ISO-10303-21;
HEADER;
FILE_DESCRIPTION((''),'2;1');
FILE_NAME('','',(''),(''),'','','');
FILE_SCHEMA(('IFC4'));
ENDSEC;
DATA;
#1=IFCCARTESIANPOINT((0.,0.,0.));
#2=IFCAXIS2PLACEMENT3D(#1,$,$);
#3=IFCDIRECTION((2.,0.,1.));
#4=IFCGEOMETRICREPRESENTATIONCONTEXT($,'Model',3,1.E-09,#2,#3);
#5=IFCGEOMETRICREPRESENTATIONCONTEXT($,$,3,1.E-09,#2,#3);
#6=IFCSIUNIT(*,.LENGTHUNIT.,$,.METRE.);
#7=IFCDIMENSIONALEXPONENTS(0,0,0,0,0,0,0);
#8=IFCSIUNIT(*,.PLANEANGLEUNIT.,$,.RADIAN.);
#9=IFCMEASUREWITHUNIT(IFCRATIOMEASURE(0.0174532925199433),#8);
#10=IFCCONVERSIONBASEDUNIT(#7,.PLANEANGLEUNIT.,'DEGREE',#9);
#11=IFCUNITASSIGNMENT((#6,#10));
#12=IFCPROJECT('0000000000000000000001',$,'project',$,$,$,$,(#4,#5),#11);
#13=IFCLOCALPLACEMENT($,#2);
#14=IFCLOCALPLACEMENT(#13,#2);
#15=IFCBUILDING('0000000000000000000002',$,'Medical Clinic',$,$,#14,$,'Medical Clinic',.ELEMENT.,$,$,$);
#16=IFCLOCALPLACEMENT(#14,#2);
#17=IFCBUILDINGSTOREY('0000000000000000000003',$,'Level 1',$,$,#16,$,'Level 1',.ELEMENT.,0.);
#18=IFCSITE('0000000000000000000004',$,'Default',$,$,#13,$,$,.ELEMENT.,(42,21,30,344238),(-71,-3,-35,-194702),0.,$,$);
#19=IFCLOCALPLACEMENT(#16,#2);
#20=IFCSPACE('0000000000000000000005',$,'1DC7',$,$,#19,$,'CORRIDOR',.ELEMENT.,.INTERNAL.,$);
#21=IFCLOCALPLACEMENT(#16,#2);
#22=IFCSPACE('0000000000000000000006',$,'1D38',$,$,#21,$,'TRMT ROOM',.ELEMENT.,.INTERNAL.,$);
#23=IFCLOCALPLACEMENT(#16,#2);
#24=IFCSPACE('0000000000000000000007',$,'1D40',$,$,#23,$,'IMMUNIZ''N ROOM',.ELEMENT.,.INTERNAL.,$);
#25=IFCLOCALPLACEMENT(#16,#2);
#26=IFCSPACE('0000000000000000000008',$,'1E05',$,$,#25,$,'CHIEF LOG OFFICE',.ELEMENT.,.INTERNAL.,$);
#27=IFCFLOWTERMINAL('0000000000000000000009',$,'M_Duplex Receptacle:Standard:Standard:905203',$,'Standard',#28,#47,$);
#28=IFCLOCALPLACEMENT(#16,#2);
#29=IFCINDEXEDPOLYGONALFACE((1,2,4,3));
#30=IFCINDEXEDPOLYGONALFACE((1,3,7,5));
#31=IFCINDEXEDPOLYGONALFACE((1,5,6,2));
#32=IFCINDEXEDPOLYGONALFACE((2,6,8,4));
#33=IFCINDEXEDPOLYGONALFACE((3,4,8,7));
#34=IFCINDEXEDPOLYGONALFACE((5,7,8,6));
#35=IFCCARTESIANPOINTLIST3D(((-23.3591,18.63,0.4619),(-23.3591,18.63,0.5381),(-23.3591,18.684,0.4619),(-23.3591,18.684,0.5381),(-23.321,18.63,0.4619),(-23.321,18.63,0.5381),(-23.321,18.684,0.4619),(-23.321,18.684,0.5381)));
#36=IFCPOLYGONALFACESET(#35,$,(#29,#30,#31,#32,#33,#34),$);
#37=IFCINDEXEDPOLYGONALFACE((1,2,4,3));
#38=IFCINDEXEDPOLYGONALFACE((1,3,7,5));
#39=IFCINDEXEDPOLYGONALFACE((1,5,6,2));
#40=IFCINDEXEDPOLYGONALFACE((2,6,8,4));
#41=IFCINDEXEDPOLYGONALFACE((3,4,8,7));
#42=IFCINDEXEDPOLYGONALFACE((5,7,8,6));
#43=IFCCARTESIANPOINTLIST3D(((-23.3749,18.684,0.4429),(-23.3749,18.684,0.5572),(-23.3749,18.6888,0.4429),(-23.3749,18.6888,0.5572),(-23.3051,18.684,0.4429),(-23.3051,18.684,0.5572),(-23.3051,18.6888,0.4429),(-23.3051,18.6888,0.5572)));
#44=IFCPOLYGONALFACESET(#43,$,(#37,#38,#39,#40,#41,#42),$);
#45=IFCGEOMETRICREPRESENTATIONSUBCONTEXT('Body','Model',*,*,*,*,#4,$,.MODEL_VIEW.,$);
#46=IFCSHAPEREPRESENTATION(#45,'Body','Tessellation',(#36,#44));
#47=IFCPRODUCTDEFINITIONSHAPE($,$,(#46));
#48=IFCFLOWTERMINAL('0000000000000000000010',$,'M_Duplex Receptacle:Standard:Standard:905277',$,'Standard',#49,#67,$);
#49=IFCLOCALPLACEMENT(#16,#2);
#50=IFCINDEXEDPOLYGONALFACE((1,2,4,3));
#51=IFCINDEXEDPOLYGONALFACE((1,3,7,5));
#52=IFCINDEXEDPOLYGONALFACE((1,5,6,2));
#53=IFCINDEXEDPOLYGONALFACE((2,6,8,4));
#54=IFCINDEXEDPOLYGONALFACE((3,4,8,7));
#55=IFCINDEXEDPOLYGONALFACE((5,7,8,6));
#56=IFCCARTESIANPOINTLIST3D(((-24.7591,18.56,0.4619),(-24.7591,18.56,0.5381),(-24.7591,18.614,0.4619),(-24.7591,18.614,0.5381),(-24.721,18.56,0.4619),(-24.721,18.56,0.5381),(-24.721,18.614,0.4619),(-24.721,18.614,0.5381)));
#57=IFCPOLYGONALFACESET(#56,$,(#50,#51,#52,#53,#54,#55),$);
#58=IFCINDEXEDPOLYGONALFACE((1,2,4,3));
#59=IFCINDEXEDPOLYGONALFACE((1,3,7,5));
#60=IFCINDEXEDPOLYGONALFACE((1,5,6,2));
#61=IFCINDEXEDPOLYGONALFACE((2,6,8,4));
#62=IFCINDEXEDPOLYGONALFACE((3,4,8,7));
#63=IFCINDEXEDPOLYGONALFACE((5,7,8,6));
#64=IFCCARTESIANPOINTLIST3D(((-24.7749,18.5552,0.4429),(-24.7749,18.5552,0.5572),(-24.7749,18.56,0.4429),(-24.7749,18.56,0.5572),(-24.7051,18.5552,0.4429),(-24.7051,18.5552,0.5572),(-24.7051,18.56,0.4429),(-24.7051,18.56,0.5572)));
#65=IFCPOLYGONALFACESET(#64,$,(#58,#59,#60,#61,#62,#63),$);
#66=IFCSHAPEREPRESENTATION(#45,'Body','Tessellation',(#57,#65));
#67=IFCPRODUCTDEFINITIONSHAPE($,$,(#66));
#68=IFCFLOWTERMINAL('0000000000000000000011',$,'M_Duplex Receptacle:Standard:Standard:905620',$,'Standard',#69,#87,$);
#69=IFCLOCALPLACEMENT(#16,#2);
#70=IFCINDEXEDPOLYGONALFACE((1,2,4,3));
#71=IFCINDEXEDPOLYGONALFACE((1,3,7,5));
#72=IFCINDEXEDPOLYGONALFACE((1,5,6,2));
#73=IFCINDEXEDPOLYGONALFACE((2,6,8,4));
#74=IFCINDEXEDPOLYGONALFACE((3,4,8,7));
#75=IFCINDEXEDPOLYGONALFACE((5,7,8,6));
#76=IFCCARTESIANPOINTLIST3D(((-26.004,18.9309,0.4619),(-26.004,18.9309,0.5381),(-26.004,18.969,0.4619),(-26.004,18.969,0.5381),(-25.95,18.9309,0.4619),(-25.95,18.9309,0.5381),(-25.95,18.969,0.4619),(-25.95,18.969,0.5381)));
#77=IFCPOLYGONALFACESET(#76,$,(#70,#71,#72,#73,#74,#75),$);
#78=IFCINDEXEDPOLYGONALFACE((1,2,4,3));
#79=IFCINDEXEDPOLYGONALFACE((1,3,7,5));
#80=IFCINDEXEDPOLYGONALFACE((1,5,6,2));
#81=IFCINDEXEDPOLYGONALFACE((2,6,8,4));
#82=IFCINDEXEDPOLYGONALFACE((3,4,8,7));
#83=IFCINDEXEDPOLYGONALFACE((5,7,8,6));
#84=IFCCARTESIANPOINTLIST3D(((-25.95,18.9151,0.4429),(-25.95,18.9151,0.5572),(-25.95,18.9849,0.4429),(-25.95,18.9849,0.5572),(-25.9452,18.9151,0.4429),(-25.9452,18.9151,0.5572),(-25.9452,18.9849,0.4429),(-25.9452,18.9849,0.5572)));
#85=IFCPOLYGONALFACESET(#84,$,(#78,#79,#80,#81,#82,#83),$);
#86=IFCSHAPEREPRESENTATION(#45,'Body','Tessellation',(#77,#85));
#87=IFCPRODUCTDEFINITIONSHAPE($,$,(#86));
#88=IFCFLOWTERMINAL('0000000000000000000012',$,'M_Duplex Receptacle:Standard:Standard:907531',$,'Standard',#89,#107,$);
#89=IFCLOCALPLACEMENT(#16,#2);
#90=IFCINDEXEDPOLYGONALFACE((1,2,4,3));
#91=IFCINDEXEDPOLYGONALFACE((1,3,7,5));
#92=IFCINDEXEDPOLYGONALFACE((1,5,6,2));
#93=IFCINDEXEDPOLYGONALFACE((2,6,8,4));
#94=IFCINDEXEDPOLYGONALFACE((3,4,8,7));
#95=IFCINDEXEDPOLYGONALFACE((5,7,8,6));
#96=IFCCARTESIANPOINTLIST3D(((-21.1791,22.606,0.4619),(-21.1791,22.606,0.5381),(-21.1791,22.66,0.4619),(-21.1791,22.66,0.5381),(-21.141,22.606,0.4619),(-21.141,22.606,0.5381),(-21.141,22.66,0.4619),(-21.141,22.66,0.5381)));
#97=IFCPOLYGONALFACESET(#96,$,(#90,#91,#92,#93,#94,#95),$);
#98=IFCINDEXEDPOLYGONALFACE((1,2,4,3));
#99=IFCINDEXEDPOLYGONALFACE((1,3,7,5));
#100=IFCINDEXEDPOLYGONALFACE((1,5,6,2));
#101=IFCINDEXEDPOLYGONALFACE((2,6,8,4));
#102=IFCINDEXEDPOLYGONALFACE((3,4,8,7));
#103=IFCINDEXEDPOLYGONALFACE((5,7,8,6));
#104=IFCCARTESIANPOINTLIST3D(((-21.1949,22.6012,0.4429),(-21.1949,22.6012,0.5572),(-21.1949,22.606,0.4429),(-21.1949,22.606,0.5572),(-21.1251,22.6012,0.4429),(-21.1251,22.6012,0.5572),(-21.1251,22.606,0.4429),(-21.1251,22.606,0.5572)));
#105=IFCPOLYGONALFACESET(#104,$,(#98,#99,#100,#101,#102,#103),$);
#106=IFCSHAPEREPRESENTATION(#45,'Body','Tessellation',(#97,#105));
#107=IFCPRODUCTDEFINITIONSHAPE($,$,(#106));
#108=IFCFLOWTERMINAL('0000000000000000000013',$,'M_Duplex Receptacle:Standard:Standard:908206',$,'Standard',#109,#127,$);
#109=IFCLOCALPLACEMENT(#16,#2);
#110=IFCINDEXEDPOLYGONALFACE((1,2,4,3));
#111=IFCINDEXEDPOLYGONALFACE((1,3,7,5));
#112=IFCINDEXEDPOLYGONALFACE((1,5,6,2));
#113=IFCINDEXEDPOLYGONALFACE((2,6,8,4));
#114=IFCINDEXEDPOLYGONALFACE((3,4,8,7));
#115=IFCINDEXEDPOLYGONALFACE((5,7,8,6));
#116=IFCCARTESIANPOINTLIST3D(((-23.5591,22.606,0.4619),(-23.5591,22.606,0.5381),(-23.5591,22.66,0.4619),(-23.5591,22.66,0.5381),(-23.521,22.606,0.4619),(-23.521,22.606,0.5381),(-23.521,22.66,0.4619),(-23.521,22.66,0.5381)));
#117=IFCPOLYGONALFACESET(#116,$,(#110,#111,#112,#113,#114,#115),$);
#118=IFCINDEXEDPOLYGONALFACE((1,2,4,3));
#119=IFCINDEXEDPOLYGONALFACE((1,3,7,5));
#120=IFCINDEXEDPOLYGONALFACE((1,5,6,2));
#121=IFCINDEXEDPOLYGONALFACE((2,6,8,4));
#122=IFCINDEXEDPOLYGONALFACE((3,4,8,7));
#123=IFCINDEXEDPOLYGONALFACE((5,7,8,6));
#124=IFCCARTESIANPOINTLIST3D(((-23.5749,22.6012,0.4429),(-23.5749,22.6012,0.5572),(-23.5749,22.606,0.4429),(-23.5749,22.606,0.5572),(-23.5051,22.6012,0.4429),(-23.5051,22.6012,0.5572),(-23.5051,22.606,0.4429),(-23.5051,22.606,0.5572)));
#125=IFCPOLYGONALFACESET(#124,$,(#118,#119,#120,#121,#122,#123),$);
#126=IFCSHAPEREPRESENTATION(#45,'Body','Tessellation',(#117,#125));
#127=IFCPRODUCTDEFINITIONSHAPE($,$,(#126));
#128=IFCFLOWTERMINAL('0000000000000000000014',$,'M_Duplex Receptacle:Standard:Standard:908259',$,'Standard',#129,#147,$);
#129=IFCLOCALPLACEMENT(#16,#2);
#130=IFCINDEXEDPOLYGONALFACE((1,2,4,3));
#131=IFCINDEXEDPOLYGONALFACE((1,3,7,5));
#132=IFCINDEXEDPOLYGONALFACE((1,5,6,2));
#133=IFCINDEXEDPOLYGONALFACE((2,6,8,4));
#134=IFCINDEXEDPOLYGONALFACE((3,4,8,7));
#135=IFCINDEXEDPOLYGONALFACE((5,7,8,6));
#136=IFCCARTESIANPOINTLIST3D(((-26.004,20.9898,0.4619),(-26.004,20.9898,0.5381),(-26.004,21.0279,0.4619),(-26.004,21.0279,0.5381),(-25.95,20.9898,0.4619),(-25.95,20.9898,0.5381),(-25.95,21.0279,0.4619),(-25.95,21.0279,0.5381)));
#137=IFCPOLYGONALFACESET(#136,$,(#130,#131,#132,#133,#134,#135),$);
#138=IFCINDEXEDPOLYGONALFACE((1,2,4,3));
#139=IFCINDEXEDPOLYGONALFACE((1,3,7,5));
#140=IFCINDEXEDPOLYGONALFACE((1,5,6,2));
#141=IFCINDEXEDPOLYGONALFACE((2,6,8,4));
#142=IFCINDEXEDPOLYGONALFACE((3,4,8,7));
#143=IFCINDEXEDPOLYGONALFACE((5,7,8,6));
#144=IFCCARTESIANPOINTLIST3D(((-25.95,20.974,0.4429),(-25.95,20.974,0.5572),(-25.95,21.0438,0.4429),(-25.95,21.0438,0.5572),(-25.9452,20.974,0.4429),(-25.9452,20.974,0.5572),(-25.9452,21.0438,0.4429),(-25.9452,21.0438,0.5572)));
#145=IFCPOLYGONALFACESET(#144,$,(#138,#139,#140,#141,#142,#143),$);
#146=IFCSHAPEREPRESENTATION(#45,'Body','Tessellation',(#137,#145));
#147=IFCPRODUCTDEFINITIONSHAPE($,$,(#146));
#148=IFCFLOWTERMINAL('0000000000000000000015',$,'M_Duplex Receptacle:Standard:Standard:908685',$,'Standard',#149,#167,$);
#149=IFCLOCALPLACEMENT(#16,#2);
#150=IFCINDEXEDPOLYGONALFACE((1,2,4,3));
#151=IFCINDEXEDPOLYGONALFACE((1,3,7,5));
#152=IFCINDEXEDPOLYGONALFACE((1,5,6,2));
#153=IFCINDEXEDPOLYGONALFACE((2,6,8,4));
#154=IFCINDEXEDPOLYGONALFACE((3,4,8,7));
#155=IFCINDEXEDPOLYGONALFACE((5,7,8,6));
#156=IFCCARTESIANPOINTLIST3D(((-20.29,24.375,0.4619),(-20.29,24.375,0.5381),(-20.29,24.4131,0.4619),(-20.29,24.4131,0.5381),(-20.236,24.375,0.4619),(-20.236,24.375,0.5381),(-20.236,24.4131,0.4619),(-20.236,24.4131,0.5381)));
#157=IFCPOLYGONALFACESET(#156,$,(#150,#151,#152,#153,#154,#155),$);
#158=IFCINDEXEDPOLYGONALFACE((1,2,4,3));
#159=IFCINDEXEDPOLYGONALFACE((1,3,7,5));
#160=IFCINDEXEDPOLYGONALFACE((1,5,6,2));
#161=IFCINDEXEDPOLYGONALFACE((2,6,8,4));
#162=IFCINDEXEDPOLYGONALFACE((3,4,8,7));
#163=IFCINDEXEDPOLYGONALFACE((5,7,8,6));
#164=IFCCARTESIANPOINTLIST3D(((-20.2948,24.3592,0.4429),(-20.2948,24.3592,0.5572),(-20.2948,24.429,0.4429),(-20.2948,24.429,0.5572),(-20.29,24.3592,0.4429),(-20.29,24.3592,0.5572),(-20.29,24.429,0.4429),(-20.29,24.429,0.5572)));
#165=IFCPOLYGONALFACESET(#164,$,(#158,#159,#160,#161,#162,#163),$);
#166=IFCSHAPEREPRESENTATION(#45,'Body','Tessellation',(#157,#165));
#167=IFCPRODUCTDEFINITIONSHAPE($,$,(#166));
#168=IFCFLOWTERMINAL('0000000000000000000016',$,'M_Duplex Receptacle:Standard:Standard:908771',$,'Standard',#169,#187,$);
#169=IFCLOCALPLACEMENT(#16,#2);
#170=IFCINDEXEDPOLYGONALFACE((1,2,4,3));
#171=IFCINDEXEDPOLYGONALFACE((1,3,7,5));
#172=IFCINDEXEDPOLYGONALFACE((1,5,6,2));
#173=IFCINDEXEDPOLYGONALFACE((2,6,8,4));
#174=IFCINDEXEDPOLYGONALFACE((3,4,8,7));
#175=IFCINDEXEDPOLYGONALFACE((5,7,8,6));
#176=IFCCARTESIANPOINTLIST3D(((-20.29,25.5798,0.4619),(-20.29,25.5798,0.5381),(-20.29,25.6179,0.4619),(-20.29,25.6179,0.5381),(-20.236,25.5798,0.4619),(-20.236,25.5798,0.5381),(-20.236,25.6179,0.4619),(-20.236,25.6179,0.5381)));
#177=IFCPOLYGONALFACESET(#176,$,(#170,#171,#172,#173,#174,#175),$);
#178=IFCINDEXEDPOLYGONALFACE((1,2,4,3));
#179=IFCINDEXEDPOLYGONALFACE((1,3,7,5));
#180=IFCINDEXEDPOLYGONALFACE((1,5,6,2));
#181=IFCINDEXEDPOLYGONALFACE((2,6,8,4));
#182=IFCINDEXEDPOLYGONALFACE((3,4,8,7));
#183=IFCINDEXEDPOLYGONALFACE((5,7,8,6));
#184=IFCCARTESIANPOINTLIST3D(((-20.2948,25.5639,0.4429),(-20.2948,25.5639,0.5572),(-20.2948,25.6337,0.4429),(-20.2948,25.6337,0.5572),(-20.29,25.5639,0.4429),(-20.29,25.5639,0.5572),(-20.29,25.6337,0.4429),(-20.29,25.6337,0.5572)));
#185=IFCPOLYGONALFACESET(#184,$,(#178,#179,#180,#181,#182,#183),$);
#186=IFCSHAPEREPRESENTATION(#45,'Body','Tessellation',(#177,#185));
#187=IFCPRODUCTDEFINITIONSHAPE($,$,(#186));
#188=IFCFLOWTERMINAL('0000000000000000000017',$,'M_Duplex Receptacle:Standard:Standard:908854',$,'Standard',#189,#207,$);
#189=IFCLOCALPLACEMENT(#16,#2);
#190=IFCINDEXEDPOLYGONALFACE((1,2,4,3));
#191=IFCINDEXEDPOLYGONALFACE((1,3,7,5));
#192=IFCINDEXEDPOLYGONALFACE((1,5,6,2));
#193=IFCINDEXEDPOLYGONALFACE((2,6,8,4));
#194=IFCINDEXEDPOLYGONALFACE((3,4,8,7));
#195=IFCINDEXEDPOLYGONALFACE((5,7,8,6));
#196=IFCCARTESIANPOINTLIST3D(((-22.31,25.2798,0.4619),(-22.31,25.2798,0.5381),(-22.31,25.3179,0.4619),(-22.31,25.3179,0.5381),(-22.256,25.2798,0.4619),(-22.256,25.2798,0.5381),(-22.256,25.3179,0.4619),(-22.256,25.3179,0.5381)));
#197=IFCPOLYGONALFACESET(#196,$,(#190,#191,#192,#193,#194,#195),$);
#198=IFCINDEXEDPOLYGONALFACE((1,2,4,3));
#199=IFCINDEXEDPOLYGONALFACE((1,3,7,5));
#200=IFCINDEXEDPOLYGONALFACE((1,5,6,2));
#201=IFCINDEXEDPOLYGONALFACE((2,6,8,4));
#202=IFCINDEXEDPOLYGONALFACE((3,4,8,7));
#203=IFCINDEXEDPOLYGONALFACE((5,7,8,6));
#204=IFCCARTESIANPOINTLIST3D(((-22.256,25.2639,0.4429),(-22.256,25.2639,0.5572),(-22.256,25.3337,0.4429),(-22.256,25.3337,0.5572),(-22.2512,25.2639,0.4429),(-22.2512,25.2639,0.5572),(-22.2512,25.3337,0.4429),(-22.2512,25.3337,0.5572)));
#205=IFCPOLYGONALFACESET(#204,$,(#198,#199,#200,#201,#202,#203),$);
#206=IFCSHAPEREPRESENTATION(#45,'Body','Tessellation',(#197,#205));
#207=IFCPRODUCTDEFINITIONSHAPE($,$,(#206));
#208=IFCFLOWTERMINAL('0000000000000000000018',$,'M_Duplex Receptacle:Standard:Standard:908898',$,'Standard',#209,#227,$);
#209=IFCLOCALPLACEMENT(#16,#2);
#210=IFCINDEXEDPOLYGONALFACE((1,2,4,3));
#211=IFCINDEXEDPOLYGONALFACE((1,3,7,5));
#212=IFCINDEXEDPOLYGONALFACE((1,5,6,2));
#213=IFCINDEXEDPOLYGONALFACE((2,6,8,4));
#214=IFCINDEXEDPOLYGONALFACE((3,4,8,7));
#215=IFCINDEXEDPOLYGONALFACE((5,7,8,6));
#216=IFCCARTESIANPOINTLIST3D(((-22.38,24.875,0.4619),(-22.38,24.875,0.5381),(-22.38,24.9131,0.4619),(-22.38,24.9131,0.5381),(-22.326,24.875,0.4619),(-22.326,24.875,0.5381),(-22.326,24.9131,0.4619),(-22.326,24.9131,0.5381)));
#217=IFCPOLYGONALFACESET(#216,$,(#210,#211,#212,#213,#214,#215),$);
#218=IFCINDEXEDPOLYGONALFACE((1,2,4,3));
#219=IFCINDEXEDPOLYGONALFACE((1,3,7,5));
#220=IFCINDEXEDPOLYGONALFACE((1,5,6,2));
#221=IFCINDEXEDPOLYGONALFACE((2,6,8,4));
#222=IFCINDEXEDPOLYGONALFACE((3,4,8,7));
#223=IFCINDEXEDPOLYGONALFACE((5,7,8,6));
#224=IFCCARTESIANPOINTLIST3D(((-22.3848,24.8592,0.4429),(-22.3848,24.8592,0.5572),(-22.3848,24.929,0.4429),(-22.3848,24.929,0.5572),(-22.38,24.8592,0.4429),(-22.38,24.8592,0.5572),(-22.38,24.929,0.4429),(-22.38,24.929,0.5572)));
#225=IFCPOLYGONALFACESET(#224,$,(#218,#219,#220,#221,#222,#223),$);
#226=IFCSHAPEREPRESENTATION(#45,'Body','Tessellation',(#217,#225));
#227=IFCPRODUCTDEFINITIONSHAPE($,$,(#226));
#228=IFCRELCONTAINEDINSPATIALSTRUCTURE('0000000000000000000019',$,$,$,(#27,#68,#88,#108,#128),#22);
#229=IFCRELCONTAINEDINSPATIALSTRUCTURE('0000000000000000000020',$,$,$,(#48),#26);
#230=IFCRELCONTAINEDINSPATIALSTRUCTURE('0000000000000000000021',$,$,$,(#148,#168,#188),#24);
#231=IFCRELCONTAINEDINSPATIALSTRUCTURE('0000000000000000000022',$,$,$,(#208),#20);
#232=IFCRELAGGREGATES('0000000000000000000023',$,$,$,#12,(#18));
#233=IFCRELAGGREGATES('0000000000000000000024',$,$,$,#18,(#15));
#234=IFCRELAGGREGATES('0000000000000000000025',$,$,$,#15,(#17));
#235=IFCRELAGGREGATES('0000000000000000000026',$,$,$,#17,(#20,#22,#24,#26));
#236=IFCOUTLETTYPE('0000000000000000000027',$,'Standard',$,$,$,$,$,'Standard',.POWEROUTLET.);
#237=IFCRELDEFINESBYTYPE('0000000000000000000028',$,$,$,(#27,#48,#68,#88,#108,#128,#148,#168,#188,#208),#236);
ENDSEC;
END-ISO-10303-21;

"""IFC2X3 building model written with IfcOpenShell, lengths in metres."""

from ifc_helpers import new_model, entity, si_unit, converted_unit, direction, frame, frame_2d, origin, origin_2d_with_axis, place, context, subcontext, project, spatial, rectangle, extrude, source, transform, mapped, type_object, type_shapes, element, save


model = new_model("IFC2X3")

# Units and contexts
model_context = context("Model", 3, precision=1e-09, world=origin(), true_north=direction((2.0, 0.0, 1.0)))
context_of_model = context(None, 3, precision=1e-09, world=origin(), true_north=direction((2.0, 0.0, 1.0)))
body_context = subcontext(model_context, "Body", "Model", "MODEL_VIEW")
ifc_project = project(units=[si_unit("LENGTHUNIT", "METRE"), converted_unit("PLANEANGLEUNIT", "DEGREE", entity("IfcRatioMeasure", 0.0174532925199433), si_unit("PLANEANGLEUNIT", "RADIAN"), dimensions=[0, 0, 0, 0, 0, 0, 0])], contexts=[model_context, context_of_model])

# Site, building, storey, space
site_placement = place(None, origin())
site = spatial("IfcSite", under=ifc_project, at=site_placement, Name="Default", CompositionType="ELEMENT", RefLatitude=(42, 21, 30, 344238), RefLongitude=(-71, -3, -35, -194702), RefElevation=0.0)
building_placement = place(site_placement, origin())
building = spatial("IfcBuilding", under=site, at=building_placement, Name="Medical Clinic", LongName="Medical Clinic", CompositionType="ELEMENT")
storey_placement = place(building_placement, origin())
storey = spatial("IfcBuildingStorey", under=building, at=storey_placement, Name="Level 1", LongName="Level 1", CompositionType="ELEMENT", Elevation=0.0)
space_1_placement = place(storey_placement, origin())
space_1 = spatial("IfcSpace", under=storey, at=space_1_placement, Name="1DC7", LongName="CORRIDOR", CompositionType="ELEMENT", InteriorOrExteriorSpace="INTERNAL")

# Shared definitions
space_2_placement = place(storey_placement, origin())
space_2 = spatial("IfcSpace", under=storey, at=space_2_placement, Name="1D38", LongName="TRMT ROOM", CompositionType="ELEMENT", InteriorOrExteriorSpace="INTERNAL")

# Shared definitions
space_3_placement = place(storey_placement, origin())
space_3 = spatial("IfcSpace", under=storey, at=space_3_placement, Name="1D40", LongName="IMMUNIZ'N ROOM", CompositionType="ELEMENT", InteriorOrExteriorSpace="INTERNAL")

# Flow terminal
outlet_type = type_object("IfcOutletType", Name="Standard", ElementType="Standard", PredefinedType="POWEROUTLET")
shared_shape_1 = source(origin(), body_context, "Body", "SweptSolid", [
    extrude(rectangle(XDim=0.0381, YDim=0.0762, at=origin_2d_with_axis()), frame((0.0, 0.0, -0.054), z_axis=(0.0, 0.0, 1.0), x_axis=(-1.0, 0.0, 0.0)), (0.0, 0.0, 1.0), 0.054),
    extrude(rectangle(XDim=0.0698, YDim=0.1143, at=frame_2d((0.0, 0.0), x_axis=(1.0, 0.0))), frame((0.0, 0.0, 0.0), z_axis=(0.0, 0.0, 1.0), x_axis=(-1.0, 0.0, 0.0)), (0.0, 0.0, 1.0), 0.0048),
])
type_shapes(outlet_type, [shared_shape_1])
for number, where, z_axis, x_axis, name in (
    (1, (-23.34, 18.684, 0.5), (0.0, 1.0, 0.0), (-1.0, 0.0, 0.0), "M_Duplex Receptacle:Standard:Standard:905203"),
):
    element("IfcFlowTerminal", number, at=place(space_2_placement, frame(where, z_axis=z_axis, x_axis=x_axis)), inside=space_2, type_object=outlet_type, Name=name, ObjectType="Standard", context=body_context, shape_type="MappedRepresentation", body=[
        mapped(shared_shape_1, transform((0.0, 0.0, 0.0), scale=1.0)),
    ])

# Shared definitions
space_4_placement = place(storey_placement, origin())
space_4 = spatial("IfcSpace", under=storey, at=space_4_placement, Name="1E05", LongName="CHIEF LOG OFFICE", CompositionType="ELEMENT", InteriorOrExteriorSpace="INTERNAL")

# Flow terminals
flow_terminal_1_placement = place(space_4_placement, frame((-24.74, 18.56, 0.5), z_axis=(0.0, -1.0, 0.0), x_axis=(1.0, 0.0, 0.0)))
element("IfcFlowTerminal", 2, at=flow_terminal_1_placement, inside=space_4, type_object=outlet_type, Name="M_Duplex Receptacle:Standard:Standard:905277", ObjectType="Standard", context=body_context, shape_type="MappedRepresentation", body=[
    mapped(shared_shape_1, transform((0.0, 0.0, 0.0), scale=1.0)),
])
for number, where, z_axis, x_axis, name in (
    (3, (-25.95, 18.95, 0.5), (1.0, 0.0, 0.0), (0.0, 1.0, 0.0), "M_Duplex Receptacle:Standard:Standard:905620"),
    (4, (-21.16, 22.606, 0.5), (0.0, -1.0, 0.0), (1.0, 0.0, 0.0), "M_Duplex Receptacle:Standard:Standard:907531"),
    (5, (-23.54, 22.606, 0.5), (0.0, -1.0, 0.0), (1.0, 0.0, 0.0), "M_Duplex Receptacle:Standard:Standard:908206"),
    (6, (-25.95, 21.0089, 0.5), (1.0, 0.0, 0.0), (0.0, 1.0, 0.0), "M_Duplex Receptacle:Standard:Standard:908259"),
):
    element("IfcFlowTerminal", number, at=place(space_2_placement, frame(where, z_axis=z_axis, x_axis=x_axis)), inside=space_2, type_object=outlet_type, Name=name, ObjectType="Standard", context=body_context, shape_type="MappedRepresentation", body=[
        mapped(shared_shape_1, transform((0.0, 0.0, 0.0), scale=1.0)),
    ])
for number, where, z_axis, x_axis, name in (
    (7, (-20.29, 24.3941, 0.5), (-1.0, 0.0, 0.0), (0.0, -1.0, 0.0), "M_Duplex Receptacle:Standard:Standard:908685"),
    (8, (-20.29, 25.5988, 0.5), (-1.0, 0.0, 0.0), (0.0, -1.0, 0.0), "M_Duplex Receptacle:Standard:Standard:908771"),
    (9, (-22.256, 25.2988, 0.5), (1.0, 0.0, 0.0), (0.0, 1.0, 0.0), "M_Duplex Receptacle:Standard:Standard:908854"),
):
    element("IfcFlowTerminal", number, at=place(space_3_placement, frame(where, z_axis=z_axis, x_axis=x_axis)), inside=space_3, type_object=outlet_type, Name=name, ObjectType="Standard", context=body_context, shape_type="MappedRepresentation", body=[
        mapped(shared_shape_1, transform((0.0, 0.0, 0.0), scale=1.0)),
    ])
flow_terminal_2_placement = place(space_1_placement, frame((-22.38, 24.8941, 0.5), z_axis=(-1.0, 0.0, 0.0), x_axis=(0.0, -1.0, 0.0)))
element("IfcFlowTerminal", 10, at=flow_terminal_2_placement, inside=space_1, type_object=outlet_type, Name="M_Duplex Receptacle:Standard:Standard:908898", ObjectType="Standard", context=body_context, shape_type="MappedRepresentation", body=[
    mapped(shared_shape_1, transform((0.0, 0.0, 0.0), scale=1.0)),
])

save(model, "model.ifc")
